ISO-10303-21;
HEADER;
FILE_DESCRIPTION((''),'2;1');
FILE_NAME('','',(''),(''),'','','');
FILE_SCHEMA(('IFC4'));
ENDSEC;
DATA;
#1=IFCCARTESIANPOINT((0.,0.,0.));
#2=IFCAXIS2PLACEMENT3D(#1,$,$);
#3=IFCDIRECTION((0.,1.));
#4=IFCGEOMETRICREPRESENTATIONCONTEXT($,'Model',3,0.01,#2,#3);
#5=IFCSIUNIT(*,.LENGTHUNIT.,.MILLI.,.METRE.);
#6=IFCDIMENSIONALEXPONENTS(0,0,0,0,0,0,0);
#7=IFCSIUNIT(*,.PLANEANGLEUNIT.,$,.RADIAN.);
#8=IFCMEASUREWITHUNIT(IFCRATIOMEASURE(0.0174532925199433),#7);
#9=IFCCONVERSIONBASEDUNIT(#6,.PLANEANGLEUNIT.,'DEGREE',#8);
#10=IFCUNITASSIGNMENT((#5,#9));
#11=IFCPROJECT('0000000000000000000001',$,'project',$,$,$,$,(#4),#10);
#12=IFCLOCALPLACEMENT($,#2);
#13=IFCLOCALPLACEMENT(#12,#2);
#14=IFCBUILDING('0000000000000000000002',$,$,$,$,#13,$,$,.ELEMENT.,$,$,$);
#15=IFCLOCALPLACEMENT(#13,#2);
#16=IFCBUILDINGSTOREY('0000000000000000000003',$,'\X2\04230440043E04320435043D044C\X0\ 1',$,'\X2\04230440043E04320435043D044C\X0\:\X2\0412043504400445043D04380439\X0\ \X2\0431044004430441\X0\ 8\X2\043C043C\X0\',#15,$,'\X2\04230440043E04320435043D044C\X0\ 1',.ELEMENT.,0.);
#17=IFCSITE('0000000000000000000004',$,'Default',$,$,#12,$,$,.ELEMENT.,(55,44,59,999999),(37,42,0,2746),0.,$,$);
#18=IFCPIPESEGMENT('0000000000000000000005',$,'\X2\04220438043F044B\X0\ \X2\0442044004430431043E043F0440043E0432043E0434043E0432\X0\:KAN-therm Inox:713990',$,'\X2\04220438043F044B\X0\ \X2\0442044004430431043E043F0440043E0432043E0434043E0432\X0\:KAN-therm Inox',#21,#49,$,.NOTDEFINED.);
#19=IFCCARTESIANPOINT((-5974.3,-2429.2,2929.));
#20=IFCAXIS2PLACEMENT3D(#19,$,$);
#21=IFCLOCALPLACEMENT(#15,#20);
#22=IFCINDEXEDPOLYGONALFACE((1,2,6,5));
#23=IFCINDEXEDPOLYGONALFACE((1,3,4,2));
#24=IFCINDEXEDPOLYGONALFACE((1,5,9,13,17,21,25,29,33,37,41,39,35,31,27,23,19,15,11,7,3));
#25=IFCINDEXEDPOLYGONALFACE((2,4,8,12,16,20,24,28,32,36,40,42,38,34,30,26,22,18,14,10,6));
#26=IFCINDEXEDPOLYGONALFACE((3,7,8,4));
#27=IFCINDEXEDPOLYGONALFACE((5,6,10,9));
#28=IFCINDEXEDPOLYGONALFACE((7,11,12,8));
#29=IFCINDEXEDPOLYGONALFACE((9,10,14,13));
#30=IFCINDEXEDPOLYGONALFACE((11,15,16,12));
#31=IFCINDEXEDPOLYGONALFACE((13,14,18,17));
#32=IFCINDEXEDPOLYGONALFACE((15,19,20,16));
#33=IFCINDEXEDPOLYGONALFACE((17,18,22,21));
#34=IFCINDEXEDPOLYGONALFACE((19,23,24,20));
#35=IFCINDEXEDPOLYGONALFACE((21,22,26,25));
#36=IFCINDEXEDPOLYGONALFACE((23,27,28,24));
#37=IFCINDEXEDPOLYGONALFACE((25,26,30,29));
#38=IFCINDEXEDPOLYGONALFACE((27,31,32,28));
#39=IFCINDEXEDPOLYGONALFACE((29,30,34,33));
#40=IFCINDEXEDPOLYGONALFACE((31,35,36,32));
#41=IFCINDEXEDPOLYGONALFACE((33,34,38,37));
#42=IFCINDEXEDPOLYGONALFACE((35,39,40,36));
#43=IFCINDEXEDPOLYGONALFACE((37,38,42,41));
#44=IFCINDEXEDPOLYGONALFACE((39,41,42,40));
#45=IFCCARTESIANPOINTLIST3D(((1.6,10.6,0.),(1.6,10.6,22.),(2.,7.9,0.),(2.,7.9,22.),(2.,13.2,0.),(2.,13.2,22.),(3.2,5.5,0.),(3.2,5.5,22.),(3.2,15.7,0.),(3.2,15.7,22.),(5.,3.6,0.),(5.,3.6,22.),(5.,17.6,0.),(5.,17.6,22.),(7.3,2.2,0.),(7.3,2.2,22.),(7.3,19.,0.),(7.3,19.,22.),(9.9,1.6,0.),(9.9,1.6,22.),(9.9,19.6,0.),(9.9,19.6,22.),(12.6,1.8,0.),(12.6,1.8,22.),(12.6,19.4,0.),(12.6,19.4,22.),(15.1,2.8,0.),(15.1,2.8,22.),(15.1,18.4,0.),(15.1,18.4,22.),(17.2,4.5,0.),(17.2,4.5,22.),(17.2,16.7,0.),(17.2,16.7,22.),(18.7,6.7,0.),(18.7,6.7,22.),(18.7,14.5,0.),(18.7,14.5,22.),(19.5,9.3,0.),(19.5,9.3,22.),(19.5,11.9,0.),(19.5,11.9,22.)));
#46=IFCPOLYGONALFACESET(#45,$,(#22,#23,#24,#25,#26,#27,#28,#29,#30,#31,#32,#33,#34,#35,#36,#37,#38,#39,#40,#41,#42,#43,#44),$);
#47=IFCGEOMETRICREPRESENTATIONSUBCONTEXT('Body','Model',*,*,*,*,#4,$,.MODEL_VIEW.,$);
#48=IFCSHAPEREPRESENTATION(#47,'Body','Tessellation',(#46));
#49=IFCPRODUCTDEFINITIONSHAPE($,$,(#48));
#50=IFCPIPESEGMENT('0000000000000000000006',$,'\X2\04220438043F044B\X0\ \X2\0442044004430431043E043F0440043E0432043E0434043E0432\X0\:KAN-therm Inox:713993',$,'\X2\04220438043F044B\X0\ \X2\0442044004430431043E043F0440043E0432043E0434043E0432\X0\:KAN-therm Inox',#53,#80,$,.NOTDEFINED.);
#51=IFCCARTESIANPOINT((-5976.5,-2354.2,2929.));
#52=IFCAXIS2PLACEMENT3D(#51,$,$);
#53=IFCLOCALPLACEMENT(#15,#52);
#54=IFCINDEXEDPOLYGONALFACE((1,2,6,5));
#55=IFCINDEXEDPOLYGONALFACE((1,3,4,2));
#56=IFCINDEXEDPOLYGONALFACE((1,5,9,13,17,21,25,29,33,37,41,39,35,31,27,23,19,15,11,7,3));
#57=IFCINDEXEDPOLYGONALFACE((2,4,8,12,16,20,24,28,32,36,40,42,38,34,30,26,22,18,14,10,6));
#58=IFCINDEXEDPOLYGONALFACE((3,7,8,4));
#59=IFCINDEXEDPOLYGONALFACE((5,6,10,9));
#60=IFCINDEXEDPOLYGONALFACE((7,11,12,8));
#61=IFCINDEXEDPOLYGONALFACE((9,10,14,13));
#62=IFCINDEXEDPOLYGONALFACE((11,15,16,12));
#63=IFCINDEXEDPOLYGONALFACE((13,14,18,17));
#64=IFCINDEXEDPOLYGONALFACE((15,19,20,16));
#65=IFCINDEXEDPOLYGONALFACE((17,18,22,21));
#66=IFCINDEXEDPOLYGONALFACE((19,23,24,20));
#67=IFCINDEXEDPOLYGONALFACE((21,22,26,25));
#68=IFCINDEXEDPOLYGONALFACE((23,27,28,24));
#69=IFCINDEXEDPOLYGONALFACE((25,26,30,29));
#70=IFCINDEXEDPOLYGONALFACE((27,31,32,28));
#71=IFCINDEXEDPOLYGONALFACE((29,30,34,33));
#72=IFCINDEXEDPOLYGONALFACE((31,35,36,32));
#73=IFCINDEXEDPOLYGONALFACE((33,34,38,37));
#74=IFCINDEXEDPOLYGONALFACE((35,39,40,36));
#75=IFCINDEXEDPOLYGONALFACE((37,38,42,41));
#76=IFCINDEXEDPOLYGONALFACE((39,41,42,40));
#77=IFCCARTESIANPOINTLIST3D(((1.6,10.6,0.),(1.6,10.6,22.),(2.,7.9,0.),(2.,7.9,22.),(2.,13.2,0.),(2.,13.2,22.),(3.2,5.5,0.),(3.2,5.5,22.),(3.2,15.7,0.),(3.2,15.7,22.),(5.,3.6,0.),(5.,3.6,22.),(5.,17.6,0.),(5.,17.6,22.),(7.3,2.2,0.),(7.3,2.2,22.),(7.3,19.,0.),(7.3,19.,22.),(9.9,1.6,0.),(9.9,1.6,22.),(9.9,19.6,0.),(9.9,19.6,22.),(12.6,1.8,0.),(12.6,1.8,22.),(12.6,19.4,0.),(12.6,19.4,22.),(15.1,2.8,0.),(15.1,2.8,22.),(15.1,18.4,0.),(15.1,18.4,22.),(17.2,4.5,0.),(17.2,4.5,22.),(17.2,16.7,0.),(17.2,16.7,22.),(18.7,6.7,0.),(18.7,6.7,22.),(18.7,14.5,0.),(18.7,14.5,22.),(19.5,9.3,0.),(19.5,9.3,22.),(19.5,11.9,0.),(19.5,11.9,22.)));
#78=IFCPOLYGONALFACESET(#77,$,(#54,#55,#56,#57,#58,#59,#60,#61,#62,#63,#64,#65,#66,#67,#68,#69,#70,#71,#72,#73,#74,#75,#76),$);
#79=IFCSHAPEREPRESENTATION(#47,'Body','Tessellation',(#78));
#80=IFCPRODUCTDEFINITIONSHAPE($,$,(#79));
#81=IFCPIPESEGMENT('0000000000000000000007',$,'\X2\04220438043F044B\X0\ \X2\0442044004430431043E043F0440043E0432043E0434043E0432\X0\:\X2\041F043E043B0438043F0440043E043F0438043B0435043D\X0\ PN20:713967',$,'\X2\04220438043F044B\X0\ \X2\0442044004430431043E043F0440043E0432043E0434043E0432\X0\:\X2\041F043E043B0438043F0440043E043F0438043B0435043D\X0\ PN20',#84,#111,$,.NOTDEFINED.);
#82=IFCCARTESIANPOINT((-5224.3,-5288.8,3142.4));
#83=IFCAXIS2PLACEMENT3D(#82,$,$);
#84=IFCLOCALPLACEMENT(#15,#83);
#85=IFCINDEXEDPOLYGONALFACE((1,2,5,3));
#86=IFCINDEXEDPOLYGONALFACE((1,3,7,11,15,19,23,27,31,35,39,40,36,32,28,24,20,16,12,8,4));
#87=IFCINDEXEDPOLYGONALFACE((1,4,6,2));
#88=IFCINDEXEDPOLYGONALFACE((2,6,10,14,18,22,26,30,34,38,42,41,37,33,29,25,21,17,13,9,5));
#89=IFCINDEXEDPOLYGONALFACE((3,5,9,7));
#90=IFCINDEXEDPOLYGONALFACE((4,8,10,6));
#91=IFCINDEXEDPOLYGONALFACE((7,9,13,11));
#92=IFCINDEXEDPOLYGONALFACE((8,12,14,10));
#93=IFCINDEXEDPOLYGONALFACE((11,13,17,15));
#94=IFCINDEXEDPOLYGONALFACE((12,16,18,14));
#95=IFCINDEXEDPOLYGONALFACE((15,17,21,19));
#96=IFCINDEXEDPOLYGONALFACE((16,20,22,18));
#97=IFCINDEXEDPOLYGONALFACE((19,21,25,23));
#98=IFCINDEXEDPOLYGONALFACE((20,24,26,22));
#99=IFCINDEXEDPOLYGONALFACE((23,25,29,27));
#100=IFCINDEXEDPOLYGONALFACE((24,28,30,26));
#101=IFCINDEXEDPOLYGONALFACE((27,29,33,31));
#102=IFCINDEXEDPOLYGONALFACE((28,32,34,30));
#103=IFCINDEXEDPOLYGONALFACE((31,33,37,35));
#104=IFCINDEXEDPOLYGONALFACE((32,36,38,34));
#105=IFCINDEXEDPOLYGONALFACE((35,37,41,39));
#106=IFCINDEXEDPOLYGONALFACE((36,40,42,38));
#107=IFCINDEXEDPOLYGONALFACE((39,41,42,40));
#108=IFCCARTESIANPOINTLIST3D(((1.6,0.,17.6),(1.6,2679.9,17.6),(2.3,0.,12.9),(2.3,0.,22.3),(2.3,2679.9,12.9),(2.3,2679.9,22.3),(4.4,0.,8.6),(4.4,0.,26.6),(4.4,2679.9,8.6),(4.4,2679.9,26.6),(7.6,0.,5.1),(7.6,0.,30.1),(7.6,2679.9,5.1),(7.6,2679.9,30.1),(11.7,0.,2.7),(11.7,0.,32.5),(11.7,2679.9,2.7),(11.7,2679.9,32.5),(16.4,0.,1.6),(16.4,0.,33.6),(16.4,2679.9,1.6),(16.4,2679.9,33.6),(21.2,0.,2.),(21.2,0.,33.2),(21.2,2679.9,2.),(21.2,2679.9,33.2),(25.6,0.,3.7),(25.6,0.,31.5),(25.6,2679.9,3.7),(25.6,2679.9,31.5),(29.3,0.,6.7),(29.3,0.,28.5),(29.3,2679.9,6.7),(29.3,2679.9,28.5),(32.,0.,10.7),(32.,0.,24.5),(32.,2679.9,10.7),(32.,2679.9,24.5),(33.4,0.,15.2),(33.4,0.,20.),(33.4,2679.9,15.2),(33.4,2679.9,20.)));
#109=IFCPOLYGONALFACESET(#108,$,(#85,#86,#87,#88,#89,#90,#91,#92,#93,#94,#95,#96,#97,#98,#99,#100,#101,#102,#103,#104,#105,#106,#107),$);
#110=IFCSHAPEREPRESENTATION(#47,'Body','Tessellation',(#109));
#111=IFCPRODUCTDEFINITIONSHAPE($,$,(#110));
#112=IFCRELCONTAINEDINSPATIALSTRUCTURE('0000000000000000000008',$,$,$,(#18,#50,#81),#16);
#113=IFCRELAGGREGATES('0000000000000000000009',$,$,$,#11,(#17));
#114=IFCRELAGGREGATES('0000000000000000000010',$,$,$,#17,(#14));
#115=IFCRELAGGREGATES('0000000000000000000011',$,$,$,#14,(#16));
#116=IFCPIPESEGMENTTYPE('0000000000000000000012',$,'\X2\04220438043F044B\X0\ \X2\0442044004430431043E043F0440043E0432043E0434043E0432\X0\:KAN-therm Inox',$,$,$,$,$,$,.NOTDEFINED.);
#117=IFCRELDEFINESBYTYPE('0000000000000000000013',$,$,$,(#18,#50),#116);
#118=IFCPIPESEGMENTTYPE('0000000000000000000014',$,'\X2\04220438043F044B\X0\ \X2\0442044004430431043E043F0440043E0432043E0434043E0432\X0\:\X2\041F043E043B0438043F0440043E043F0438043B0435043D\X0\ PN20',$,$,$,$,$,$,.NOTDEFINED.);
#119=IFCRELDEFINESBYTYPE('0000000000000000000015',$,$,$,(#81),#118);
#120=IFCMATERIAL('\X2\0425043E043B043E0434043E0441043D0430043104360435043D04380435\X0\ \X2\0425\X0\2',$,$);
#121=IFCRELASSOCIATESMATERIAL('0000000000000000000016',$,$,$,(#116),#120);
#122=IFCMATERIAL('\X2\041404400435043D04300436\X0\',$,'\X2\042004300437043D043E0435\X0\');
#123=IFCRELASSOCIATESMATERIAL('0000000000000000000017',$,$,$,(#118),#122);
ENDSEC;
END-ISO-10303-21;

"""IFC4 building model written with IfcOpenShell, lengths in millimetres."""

from ifc_helpers import new_model, entity, si_unit, converted_unit, direction, frame, frame_2d, origin, origin_2d_with_axis, place, context, subcontext, project, spatial, circle, extrude, material, type_object, element, save


model = new_model("IFC4")

# Units and contexts
model_context = context("Model", 3, precision=0.01, world=origin(), true_north=direction((0.0, 1.0)))
body_context = subcontext(model_context, "Body", "Model", "MODEL_VIEW")
ifc_project = project(units=[si_unit("LENGTHUNIT", "METRE", prefix="MILLI"), converted_unit("PLANEANGLEUNIT", "DEGREE", entity("IfcRatioMeasure", 0.0174532925199433), si_unit("PLANEANGLEUNIT", "RADIAN"), dimensions=[0, 0, 0, 0, 0, 0, 0])], contexts=[model_context])

# Site, building, storey
site_placement = place(None, origin())
site = spatial("IfcSite", under=ifc_project, at=site_placement, Name="Default", CompositionType="ELEMENT", RefLatitude=(55, 44, 59, 999999), RefLongitude=(37, 42, 0, 2746), RefElevation=0.0)
building_placement = place(site_placement, origin())
building = spatial("IfcBuilding", under=site, at=building_placement, CompositionType="ELEMENT")
storey_placement = place(building_placement, origin())
storey = spatial("IfcBuildingStorey", under=building, at=storey_placement, Name="Уровень 1", ObjectType="Уровень:Верхний брус 8мм", LongName="Уровень 1", CompositionType="ELEMENT", Elevation=0.0)

# Shared definitions
ifc_material_1 = material(Name="Холодоснабжение Х2")

# Shared definitions
pipe_segment_type_1 = type_object("IfcPipeSegmentType", Name="Типы трубопроводов:KAN-therm Inox", PredefinedType="NOTDEFINED", material=ifc_material_1)

# Pipe segments
for number, where, name in (
    (1, (-5974.3, -2429.2, 2929.0), "Типы трубопроводов:KAN-therm Inox:713990"),
    (2, (-5976.5, -2354.2, 2929.0), "Типы трубопроводов:KAN-therm Inox:713993"),
):
    element("IfcPipeSegment", number, at=place(storey_placement, frame(where)), inside=storey, type_object=pipe_segment_type_1, Name=name, ObjectType="Типы трубопроводов:KAN-therm Inox", PredefinedType="NOTDEFINED", context=body_context, shape_type="SweptSolid", body=[
        extrude(circle(Radius=9.0, at=origin_2d_with_axis()), frame((10.6, 10.6, 0.0), z_axis=(0.0, 0.0, 1.0), x_axis=(-1.0, 0.0, 0.0)), (0.0, 0.0, 1.0), 22.0),
    ])
ifc_material_2 = material(Name="Дренаж", Category="Разное")
pipe_segment_type_2 = type_object("IfcPipeSegmentType", Name="Типы трубопроводов:Полипропилен PN20", PredefinedType="NOTDEFINED", material=ifc_material_2)
pipe_segment_1_placement = place(storey_placement, frame((-5224.3, -5288.8, 3142.4)))
element("IfcPipeSegment", 3, at=pipe_segment_1_placement, inside=storey, type_object=pipe_segment_type_2, Name="Типы трубопроводов:Полипропилен PN20:713967", ObjectType="Типы трубопроводов:Полипропилен PN20", PredefinedType="NOTDEFINED", context=body_context, shape_type="SweptSolid", body=[
    extrude(circle(Radius=16.0, at=frame_2d((0.0, 0.0), x_axis=(1.0, 0.0))), frame((17.6, 0.0, 17.6), z_axis=(0.0, 1.0, 0.0), x_axis=(-1.0, 0.0, 0.0)), (0.0, 0.0, 1.0), 2679.9),
])

save(model, "model.ifc")
